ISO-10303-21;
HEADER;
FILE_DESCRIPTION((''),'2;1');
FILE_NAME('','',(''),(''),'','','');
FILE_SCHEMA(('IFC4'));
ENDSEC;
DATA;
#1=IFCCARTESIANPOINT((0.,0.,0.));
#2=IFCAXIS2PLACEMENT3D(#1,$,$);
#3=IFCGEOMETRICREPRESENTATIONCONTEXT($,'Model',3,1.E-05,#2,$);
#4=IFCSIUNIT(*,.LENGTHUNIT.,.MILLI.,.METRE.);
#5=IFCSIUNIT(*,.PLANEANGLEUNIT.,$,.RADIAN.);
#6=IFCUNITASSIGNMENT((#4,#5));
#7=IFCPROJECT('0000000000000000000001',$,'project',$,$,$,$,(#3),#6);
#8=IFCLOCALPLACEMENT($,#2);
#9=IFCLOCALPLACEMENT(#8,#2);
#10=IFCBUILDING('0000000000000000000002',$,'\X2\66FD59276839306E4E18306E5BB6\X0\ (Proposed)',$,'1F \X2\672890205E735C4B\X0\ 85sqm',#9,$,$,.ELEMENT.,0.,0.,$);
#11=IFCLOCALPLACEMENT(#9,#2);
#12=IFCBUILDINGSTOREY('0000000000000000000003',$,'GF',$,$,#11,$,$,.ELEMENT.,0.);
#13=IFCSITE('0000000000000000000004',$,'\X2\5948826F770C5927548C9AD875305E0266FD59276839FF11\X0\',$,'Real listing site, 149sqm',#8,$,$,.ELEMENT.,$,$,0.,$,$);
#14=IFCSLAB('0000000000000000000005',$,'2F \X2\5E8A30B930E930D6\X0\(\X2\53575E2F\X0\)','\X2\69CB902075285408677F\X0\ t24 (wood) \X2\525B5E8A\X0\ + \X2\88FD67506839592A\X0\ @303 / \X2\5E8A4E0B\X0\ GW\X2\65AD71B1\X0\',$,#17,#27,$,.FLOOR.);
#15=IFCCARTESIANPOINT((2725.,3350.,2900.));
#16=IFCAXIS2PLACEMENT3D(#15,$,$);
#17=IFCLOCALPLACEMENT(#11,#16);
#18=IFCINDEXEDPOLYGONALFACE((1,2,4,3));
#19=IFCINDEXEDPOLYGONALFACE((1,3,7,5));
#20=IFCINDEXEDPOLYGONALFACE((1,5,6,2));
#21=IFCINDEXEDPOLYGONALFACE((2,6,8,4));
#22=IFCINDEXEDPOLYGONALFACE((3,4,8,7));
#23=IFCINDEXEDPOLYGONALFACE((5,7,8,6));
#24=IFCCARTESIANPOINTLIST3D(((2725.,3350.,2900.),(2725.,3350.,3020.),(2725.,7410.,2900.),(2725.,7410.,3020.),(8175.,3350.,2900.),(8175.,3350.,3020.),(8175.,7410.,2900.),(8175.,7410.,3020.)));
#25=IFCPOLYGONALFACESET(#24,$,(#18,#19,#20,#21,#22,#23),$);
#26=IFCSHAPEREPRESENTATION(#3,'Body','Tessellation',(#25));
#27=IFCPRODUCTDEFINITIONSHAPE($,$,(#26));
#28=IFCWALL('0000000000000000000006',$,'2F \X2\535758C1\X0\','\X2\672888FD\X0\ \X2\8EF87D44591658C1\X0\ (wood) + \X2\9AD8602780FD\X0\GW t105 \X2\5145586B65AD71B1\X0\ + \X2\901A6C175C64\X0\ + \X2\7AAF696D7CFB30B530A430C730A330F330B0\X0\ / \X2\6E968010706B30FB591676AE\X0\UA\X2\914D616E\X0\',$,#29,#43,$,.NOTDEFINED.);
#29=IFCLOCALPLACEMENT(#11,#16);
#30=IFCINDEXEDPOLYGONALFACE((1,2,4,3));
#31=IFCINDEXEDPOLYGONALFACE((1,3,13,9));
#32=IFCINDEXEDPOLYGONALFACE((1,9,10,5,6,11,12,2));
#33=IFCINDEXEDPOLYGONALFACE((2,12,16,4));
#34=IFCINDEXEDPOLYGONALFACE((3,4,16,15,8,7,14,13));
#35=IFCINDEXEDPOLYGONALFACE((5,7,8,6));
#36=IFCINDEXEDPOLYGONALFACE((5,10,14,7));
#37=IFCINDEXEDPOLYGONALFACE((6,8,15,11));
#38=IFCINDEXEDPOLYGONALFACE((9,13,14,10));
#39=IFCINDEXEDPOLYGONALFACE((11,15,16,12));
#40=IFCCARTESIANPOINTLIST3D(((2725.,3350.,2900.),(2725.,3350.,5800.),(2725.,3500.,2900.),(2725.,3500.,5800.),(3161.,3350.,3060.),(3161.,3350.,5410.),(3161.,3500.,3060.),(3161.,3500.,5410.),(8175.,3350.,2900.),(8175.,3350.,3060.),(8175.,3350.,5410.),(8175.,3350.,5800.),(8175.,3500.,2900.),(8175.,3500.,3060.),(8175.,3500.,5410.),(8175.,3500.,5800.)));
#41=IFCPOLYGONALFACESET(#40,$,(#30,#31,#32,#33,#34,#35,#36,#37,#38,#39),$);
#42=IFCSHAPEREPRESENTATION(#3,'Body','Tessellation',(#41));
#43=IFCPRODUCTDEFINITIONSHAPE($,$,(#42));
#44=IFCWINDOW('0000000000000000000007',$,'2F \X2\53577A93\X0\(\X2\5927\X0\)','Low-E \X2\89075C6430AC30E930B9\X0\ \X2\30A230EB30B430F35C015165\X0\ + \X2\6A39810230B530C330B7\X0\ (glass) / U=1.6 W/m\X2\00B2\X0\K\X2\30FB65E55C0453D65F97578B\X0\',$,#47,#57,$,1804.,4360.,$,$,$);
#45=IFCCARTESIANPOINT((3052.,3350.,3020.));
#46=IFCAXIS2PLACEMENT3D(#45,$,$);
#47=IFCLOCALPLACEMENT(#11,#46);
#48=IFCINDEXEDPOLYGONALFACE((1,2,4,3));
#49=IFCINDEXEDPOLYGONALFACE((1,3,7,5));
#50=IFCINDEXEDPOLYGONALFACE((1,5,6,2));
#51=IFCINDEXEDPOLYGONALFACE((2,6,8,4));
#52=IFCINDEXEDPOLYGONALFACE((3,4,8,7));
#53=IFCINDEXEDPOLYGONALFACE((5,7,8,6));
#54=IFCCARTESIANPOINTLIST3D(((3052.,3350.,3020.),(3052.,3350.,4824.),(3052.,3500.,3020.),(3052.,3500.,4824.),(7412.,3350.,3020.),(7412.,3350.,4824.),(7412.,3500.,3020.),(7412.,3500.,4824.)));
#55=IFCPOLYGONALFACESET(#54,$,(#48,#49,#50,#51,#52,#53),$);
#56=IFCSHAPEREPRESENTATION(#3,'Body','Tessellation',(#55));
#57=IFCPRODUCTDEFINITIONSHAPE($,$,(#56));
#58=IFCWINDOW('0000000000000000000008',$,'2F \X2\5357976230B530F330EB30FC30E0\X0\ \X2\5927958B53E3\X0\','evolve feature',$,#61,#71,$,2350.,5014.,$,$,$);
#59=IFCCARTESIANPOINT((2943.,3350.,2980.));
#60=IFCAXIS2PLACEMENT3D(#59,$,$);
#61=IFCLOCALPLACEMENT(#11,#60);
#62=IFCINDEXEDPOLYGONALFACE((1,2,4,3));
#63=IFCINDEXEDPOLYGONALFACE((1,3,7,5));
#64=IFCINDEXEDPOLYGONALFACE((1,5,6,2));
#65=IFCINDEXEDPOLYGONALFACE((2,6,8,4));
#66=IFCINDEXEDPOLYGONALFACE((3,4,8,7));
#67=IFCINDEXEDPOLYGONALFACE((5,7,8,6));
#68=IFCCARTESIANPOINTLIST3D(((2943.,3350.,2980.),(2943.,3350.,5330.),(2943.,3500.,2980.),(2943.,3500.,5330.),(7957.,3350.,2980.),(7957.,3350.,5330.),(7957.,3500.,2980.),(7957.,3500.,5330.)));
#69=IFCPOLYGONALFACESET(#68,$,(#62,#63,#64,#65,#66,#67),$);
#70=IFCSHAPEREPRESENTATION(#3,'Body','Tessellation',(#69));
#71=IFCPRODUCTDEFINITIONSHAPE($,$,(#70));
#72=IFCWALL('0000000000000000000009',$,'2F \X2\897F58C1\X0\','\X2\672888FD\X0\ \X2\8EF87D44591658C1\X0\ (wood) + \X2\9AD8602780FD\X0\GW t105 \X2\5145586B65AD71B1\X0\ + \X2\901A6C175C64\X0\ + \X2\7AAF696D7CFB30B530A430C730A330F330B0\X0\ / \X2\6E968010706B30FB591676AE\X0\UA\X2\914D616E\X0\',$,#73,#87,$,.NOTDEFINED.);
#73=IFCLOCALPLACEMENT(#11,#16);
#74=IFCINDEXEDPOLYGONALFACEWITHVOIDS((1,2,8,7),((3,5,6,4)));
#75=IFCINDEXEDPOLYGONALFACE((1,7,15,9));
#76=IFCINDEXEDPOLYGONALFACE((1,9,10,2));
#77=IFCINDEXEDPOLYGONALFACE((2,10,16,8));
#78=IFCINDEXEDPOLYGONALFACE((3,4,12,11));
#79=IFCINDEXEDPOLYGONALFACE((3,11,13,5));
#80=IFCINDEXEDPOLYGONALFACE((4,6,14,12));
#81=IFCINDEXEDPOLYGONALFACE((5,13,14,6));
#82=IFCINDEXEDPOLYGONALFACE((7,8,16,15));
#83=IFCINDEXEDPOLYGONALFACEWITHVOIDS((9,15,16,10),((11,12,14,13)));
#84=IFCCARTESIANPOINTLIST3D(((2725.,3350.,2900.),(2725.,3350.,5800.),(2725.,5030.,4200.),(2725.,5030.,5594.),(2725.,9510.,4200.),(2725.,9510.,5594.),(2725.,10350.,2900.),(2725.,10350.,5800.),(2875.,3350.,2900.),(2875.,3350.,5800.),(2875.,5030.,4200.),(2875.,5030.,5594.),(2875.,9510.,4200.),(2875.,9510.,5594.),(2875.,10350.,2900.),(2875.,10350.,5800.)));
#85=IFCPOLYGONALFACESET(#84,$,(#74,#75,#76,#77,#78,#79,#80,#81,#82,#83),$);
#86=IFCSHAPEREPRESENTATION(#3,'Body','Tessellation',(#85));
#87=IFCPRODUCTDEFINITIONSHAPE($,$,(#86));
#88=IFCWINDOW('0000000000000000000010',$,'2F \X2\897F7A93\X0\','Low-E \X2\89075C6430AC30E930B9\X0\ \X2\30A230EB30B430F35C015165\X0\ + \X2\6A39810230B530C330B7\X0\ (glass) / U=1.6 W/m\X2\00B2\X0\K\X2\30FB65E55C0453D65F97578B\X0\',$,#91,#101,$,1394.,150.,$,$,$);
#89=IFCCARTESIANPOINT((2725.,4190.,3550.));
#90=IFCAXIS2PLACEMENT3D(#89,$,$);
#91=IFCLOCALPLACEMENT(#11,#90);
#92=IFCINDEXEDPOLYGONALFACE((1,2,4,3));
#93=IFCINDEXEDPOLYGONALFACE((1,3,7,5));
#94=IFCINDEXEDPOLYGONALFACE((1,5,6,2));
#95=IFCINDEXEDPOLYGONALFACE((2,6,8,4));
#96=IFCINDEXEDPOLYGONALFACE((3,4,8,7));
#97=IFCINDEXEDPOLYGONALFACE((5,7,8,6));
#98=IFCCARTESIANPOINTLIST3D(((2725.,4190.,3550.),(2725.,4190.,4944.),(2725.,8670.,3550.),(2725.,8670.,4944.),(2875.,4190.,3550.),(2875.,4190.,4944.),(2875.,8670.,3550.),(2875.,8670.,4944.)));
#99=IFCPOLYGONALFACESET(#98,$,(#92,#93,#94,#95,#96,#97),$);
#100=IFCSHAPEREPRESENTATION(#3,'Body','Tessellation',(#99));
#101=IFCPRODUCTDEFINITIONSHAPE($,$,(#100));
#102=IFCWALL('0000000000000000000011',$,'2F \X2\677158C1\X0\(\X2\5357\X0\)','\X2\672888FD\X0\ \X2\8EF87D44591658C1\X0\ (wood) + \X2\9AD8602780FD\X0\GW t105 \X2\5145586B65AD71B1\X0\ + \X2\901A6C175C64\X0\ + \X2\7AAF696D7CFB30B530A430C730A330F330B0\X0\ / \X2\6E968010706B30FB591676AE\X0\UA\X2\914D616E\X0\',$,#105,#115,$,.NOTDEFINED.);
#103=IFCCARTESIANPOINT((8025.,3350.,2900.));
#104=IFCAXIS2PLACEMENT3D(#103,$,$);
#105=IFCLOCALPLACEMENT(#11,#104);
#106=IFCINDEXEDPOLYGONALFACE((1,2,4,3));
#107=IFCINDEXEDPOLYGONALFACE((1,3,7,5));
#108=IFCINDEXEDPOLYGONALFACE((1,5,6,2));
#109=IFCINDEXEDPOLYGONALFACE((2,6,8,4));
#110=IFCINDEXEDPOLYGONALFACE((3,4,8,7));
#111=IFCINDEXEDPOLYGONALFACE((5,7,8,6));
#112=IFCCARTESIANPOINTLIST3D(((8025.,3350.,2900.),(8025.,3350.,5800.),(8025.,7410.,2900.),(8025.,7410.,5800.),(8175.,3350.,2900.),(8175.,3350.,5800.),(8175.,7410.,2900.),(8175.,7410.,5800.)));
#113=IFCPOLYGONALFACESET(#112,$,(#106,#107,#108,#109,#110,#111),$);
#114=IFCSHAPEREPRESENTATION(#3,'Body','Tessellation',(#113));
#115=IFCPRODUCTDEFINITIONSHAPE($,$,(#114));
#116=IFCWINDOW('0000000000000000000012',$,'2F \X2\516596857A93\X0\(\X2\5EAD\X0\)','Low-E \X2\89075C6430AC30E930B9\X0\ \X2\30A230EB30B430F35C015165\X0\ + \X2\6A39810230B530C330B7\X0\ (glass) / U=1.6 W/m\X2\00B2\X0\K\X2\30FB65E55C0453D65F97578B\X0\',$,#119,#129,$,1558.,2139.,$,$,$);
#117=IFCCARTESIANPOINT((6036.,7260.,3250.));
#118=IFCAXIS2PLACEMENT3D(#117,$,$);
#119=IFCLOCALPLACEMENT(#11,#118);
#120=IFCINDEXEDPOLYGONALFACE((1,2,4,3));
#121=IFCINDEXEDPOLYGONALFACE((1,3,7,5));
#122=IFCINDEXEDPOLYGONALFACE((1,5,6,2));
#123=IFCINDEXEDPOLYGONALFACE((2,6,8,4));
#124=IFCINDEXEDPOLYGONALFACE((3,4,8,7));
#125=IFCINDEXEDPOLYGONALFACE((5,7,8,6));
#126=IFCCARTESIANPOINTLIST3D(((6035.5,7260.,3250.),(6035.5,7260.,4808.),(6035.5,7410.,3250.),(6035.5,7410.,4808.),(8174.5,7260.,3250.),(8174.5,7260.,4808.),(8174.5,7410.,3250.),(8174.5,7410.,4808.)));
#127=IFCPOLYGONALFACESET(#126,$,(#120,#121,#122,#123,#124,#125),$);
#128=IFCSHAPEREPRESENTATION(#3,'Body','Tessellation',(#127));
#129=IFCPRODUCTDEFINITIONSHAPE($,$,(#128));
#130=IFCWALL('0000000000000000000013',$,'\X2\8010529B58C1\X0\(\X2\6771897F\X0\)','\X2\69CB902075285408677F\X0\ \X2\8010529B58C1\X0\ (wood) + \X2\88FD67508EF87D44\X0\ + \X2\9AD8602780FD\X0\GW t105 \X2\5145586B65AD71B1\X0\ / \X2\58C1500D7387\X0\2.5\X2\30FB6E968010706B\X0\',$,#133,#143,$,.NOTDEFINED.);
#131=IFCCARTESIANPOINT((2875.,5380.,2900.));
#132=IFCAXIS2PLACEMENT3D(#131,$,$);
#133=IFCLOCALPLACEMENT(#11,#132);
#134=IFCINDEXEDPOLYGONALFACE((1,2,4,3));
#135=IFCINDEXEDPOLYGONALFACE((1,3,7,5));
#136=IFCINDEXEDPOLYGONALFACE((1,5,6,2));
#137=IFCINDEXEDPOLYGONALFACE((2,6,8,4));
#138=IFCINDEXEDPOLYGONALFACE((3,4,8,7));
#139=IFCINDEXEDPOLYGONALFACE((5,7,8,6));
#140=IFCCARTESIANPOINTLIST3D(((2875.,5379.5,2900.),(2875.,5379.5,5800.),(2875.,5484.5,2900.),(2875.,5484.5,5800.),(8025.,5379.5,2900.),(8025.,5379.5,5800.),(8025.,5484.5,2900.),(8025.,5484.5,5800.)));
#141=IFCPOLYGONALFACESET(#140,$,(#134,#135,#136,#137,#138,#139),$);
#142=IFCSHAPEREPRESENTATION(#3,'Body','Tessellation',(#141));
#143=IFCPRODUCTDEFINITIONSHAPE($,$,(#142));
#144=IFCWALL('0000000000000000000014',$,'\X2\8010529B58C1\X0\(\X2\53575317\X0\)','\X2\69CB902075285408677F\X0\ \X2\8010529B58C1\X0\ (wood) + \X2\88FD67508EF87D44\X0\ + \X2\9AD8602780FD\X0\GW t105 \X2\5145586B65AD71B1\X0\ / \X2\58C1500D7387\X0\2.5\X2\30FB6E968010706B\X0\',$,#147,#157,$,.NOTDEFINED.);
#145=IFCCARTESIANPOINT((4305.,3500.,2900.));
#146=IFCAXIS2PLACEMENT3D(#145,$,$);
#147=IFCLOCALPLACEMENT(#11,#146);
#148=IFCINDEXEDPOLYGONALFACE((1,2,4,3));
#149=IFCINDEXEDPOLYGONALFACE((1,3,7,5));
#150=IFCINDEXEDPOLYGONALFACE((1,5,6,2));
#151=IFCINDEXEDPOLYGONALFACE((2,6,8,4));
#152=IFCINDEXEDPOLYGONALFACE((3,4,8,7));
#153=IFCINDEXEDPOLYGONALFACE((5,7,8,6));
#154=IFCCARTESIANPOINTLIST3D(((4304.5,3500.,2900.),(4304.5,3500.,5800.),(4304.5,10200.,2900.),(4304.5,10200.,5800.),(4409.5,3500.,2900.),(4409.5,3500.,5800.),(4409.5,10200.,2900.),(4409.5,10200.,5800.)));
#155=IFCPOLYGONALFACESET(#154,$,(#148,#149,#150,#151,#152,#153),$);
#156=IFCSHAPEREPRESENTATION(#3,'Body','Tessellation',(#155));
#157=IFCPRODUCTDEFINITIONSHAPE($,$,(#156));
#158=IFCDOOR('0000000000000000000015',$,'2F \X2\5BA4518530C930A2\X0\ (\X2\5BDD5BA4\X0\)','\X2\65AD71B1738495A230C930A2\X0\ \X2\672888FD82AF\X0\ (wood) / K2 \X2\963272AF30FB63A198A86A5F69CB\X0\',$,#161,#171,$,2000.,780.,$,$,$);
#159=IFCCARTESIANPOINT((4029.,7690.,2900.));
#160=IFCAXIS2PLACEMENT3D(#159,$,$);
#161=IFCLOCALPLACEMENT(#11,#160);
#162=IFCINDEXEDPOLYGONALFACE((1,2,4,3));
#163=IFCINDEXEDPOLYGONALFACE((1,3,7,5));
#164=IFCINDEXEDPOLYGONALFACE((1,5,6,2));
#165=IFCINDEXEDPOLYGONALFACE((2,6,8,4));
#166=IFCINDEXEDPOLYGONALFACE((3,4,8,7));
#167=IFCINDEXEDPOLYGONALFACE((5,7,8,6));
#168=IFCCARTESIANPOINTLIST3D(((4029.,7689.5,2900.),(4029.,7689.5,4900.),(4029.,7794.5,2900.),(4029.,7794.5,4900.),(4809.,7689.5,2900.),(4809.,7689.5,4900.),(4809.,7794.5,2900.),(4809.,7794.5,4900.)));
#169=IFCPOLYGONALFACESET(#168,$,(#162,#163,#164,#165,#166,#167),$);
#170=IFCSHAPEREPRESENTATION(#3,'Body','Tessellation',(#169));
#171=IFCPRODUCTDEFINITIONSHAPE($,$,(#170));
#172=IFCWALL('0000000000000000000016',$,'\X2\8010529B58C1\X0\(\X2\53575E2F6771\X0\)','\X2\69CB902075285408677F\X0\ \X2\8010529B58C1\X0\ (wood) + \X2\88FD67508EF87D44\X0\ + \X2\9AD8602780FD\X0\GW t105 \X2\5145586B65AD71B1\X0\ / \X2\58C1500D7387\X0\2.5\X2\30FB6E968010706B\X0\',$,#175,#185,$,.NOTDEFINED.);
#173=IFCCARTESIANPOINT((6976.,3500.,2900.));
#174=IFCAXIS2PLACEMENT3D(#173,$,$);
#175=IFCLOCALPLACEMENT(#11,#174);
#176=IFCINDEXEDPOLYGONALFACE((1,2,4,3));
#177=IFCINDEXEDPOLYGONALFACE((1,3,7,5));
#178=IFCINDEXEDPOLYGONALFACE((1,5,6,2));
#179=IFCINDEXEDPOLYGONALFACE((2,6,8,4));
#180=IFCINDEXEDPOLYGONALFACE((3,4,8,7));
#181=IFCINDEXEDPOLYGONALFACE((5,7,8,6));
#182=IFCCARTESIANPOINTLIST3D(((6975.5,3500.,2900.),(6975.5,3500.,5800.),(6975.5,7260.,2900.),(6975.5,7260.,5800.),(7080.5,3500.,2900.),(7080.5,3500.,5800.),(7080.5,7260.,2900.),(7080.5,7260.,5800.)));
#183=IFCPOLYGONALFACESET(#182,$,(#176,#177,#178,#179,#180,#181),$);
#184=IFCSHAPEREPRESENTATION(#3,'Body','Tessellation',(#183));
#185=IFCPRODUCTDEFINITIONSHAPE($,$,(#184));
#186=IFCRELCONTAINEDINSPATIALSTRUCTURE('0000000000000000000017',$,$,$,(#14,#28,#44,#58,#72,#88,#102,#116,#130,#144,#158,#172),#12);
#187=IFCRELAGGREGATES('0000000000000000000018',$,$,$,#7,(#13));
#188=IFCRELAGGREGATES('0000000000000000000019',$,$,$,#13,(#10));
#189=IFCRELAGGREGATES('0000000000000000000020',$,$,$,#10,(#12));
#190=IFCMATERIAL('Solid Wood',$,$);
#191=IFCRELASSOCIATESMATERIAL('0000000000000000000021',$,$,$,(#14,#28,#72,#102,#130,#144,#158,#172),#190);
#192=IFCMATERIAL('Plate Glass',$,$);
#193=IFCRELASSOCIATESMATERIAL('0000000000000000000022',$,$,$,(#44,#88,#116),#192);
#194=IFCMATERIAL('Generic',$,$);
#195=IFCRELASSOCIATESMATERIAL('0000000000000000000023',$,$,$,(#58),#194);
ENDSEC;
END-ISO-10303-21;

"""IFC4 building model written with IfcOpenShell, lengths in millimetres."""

from ifc_helpers import new_model, si_unit, frame, frame_2d, origin, place, context, project, spatial, rectangle, extrude, material, element, fill, save


model = new_model("IFC4")

# Units and contexts
model_context = context("Model", 3, precision=1e-05, world=origin())
ifc_project = project(units=[si_unit("LENGTHUNIT", "METRE", prefix="MILLI"), si_unit("PLANEANGLEUNIT", "RADIAN")], contexts=[model_context])

# Site, building, storey
site_placement = place(None, origin())
site = spatial("IfcSite", under=ifc_project, at=site_placement, Name="奈良県大和高田市曽大根１", ObjectType="Real listing site, 149sqm", CompositionType="ELEMENT", RefElevation=0.0)
building_placement = place(site_placement, origin())
building = spatial("IfcBuilding", under=site, at=building_placement, Name="曽大根の丘の家 (Proposed)", ObjectType="1F 木造平屋 85sqm", CompositionType="ELEMENT", ElevationOfRefHeight=0.0, ElevationOfTerrain=0.0)
storey_placement = place(building_placement, origin())
storey = spatial("IfcBuildingStorey", under=building, at=storey_placement, Name="GF", CompositionType="ELEMENT", Elevation=0.0)

# Slab
ifc_material_1 = material(Name="Solid Wood")
slab_placement = place(storey_placement, frame((2725.0, 3350.0, 2900.0)))
element("IfcSlab", 1, at=slab_placement, inside=storey, material=ifc_material_1, Name="2F 床スラブ(南帯)", Description="構造用合板 t24 (wood) 剛床 + 製材根太 @303 / 床下 GW断熱", PredefinedType="FLOOR", context=model_context, shape_type="SweptSolid", body=[
    extrude(rectangle(XDim=5450.0, YDim=4060.0, at=frame_2d((2725.0, 2030.0))), frame((2725.0, 3350.0, 2900.0)), (0.0, 0.0, 1.0), 120.0),
])

# Wall, openings, windows
wall_1_placement = place(storey_placement, frame((2725.0, 3350.0, 2900.0)))
wall_1 = element("IfcWall", 2, at=wall_1_placement, inside=storey, material=ifc_material_1, Name="2F 南壁", Description="木製 軸組外壁 (wood) + 高性能GW t105 充填断熱 + 通気層 + 窯業系サイディング / 準耐火・外皮UA配慮", PredefinedType="NOTDEFINED", context=model_context, shape_type="SweptSolid", body=[
    extrude(rectangle(XDim=5450.0, YDim=150.0, at=frame_2d((2725.0, 75.0))), frame((2725.0, 3350.0, 2900.0)), (0.0, 0.0, 1.0), 2900.0),
])
opening_1_placement = place(storey_placement, frame((3052.0, 3350.0, 3020.0)))
opening_1 = element("IfcOpeningElement", 3, at=opening_1_placement, cuts=wall_1, PredefinedType="NOTDEFINED", context=model_context, shape_type="SweptSolid", body=[
    extrude(rectangle(XDim=4360.0, YDim=150.0, at=frame_2d((2180.0, 75.0))), frame((3052.0, 3350.0, 3020.0)), (0.0, 0.0, 1.0), 1804.0),
])
opening_2_placement = place(storey_placement, frame((2943.0, 3350.0, 2980.0)))
opening_2 = element("IfcOpeningElement", 4, at=opening_2_placement, cuts=wall_1, PredefinedType="NOTDEFINED", context=model_context, shape_type="SweptSolid", body=[
    extrude(rectangle(XDim=5014.0, YDim=150.0, at=frame_2d((2507.0, 75.0))), frame((2943.0, 3350.0, 2980.0)), (0.0, 0.0, 1.0), 2350.0),
])
ifc_material_2 = material(Name="Plate Glass")
window_1_placement = place(storey_placement, frame((3052.0, 3350.0, 3020.0)))
window_1 = element("IfcWindow", 5, at=window_1_placement, inside=storey, material=ifc_material_2, Name="2F 南窓(大)", Description="Low-E 複層ガラス アルゴン封入 + 樹脂サッシ (glass) / U=1.6 W/m²K・日射取得型", OverallHeight=1804.0, OverallWidth=4360.0, context=model_context, shape_type="SweptSolid", body=[
    extrude(rectangle(XDim=4360.0, YDim=150.0, at=frame_2d((2180.0, 75.0))), frame((3052.0, 3350.0, 3020.0)), (0.0, 0.0, 1.0), 1804.0),
])
fill(opening_1, window_1)
ifc_material_3 = material(Name="Generic")
window_2_placement = place(storey_placement, frame((2943.0, 3350.0, 2980.0)))
window_2 = element("IfcWindow", 6, at=window_2_placement, inside=storey, material=ifc_material_3, Name="2F 南面サンルーム 大開口", Description="evolve feature", OverallHeight=2350.0, OverallWidth=5014.0, context=model_context, shape_type="SweptSolid", body=[
    extrude(rectangle(XDim=5014.0, YDim=150.0, at=frame_2d((2507.0, 75.0))), frame((2943.0, 3350.0, 2980.0)), (0.0, 0.0, 1.0), 2350.0),
])
fill(opening_2, window_2)

# Walls, openings, windows
wall_2_placement = place(storey_placement, frame((2725.0, 3350.0, 2900.0)))
wall_2 = element("IfcWall", 7, at=wall_2_placement, inside=storey, material=ifc_material_1, Name="2F 西壁", Description="木製 軸組外壁 (wood) + 高性能GW t105 充填断熱 + 通気層 + 窯業系サイディング / 準耐火・外皮UA配慮", PredefinedType="NOTDEFINED", context=model_context, shape_type="SweptSolid", body=[
    extrude(rectangle(XDim=150.0, YDim=7000.0, at=frame_2d((75.0, 3500.0))), frame((2725.0, 3350.0, 2900.0)), (0.0, 0.0, 1.0), 2900.0),
])
opening_3_placement = place(storey_placement, frame((2725.0, 4190.0, 3550.0)))
opening_3 = element("IfcOpeningElement", 8, at=opening_3_placement, cuts=wall_2, PredefinedType="NOTDEFINED", context=model_context, shape_type="SweptSolid", body=[
    extrude(rectangle(XDim=150.0, YDim=4480.0, at=frame_2d((75.0, 2240.0))), frame((2725.0, 4190.0, 3550.0)), (0.0, 0.0, 1.0), 1394.0),
])
window_3_placement = place(storey_placement, frame((2725.0, 4190.0, 3550.0)))
window_3 = element("IfcWindow", 9, at=window_3_placement, inside=storey, material=ifc_material_2, Name="2F 西窓", Description="Low-E 複層ガラス アルゴン封入 + 樹脂サッシ (glass) / U=1.6 W/m²K・日射取得型", OverallHeight=1394.0, OverallWidth=150.0, context=model_context, shape_type="SweptSolid", body=[
    extrude(rectangle(XDim=150.0, YDim=4480.0, at=frame_2d((75.0, 2240.0))), frame((2725.0, 4190.0, 3550.0)), (0.0, 0.0, 1.0), 1394.0),
])
fill(opening_3, window_3)
wall_3_placement = place(storey_placement, frame((8025.0, 3350.0, 2900.0)))
wall_3 = element("IfcWall", 10, at=wall_3_placement, inside=storey, material=ifc_material_1, Name="2F 東壁(南)", Description="木製 軸組外壁 (wood) + 高性能GW t105 充填断熱 + 通気層 + 窯業系サイディング / 準耐火・外皮UA配慮", PredefinedType="NOTDEFINED", context=model_context, shape_type="SweptSolid", body=[
    extrude(rectangle(XDim=150.0, YDim=4060.0, at=frame_2d((75.0, 2030.0))), frame((8025.0, 3350.0, 2900.0)), (0.0, 0.0, 1.0), 2900.0),
])
opening_4_placement = place(storey_placement, frame((6036.0, 7260.0, 3250.0)))
opening_4 = element("IfcOpeningElement", 11, at=opening_4_placement, cuts=wall_3, PredefinedType="NOTDEFINED", context=model_context, shape_type="SweptSolid", body=[
    extrude(rectangle(XDim=2139.0, YDim=150.0, at=frame_2d((1069.0, 75.0))), frame((6036.0, 7260.0, 3250.0)), (0.0, 0.0, 1.0), 1558.0),
])
window_4_placement = place(storey_placement, frame((6036.0, 7260.0, 3250.0)))
window_4 = element("IfcWindow", 12, at=window_4_placement, inside=storey, material=ifc_material_2, Name="2F 入隅窓(庭)", Description="Low-E 複層ガラス アルゴン封入 + 樹脂サッシ (glass) / U=1.6 W/m²K・日射取得型", OverallHeight=1558.0, OverallWidth=2139.0, context=model_context, shape_type="SweptSolid", body=[
    extrude(rectangle(XDim=2139.0, YDim=150.0, at=frame_2d((1069.0, 75.0))), frame((6036.0, 7260.0, 3250.0)), (0.0, 0.0, 1.0), 1558.0),
])
fill(opening_4, window_4)

# Wall
wall_4_placement = place(storey_placement, frame((2875.0, 5380.0, 2900.0)))
element("IfcWall", 13, at=wall_4_placement, inside=storey, material=ifc_material_1, Name="耐力壁(東西)", Description="構造用合板 耐力壁 (wood) + 製材軸組 + 高性能GW t105 充填断熱 / 壁倍率2.5・準耐火", PredefinedType="NOTDEFINED", context=model_context, shape_type="SweptSolid", body=[
    extrude(rectangle(XDim=5150.0, YDim=105.0, at=frame_2d((2575.0, 52.0))), frame((2875.0, 5380.0, 2900.0)), (0.0, 0.0, 1.0), 2900.0),
])

# Wall, opening, door
wall_5_placement = place(storey_placement, frame((4305.0, 3500.0, 2900.0)))
wall_5 = element("IfcWall", 14, at=wall_5_placement, inside=storey, material=ifc_material_1, Name="耐力壁(南北)", Description="構造用合板 耐力壁 (wood) + 製材軸組 + 高性能GW t105 充填断熱 / 壁倍率2.5・準耐火", PredefinedType="NOTDEFINED", context=model_context, shape_type="SweptSolid", body=[
    extrude(rectangle(XDim=105.0, YDim=6700.0, at=frame_2d((52.0, 3350.0))), frame((4305.0, 3500.0, 2900.0)), (0.0, 0.0, 1.0), 2900.0),
])
opening_5_placement = place(storey_placement, frame((4029.0, 7690.0, 2900.0)))
opening_5 = element("IfcOpeningElement", 15, at=opening_5_placement, cuts=wall_5, PredefinedType="NOTDEFINED", context=model_context, shape_type="SweptSolid", body=[
    extrude(rectangle(XDim=780.0, YDim=105.0, at=frame_2d((390.0, 52.0))), frame((4029.0, 7690.0, 2900.0)), (0.0, 0.0, 1.0), 2000.0),
])
door_placement = place(storey_placement, frame((4029.0, 7690.0, 2900.0)))
door = element("IfcDoor", 16, at=door_placement, inside=storey, material=ifc_material_1, Name="2F 室内ドア (寝室)", Description="断熱玄関ドア 木製芯 (wood) / K2 防犯・採風機構", OverallHeight=2000.0, OverallWidth=780.0, context=model_context, shape_type="SweptSolid", body=[
    extrude(rectangle(XDim=780.0, YDim=105.0, at=frame_2d((390.0, 52.0))), frame((4029.0, 7690.0, 2900.0)), (0.0, 0.0, 1.0), 2000.0),
])
fill(opening_5, door)

# Wall
wall_6_placement = place(storey_placement, frame((6976.0, 3500.0, 2900.0)))
element("IfcWall", 17, at=wall_6_placement, inside=storey, material=ifc_material_1, Name="耐力壁(南帯東)", Description="構造用合板 耐力壁 (wood) + 製材軸組 + 高性能GW t105 充填断熱 / 壁倍率2.5・準耐火", PredefinedType="NOTDEFINED", context=model_context, shape_type="SweptSolid", body=[
    extrude(rectangle(XDim=105.0, YDim=3760.0, at=frame_2d((52.0, 1880.0))), frame((6976.0, 3500.0, 2900.0)), (0.0, 0.0, 1.0), 2900.0),
])

save(model, "model.ifc")
